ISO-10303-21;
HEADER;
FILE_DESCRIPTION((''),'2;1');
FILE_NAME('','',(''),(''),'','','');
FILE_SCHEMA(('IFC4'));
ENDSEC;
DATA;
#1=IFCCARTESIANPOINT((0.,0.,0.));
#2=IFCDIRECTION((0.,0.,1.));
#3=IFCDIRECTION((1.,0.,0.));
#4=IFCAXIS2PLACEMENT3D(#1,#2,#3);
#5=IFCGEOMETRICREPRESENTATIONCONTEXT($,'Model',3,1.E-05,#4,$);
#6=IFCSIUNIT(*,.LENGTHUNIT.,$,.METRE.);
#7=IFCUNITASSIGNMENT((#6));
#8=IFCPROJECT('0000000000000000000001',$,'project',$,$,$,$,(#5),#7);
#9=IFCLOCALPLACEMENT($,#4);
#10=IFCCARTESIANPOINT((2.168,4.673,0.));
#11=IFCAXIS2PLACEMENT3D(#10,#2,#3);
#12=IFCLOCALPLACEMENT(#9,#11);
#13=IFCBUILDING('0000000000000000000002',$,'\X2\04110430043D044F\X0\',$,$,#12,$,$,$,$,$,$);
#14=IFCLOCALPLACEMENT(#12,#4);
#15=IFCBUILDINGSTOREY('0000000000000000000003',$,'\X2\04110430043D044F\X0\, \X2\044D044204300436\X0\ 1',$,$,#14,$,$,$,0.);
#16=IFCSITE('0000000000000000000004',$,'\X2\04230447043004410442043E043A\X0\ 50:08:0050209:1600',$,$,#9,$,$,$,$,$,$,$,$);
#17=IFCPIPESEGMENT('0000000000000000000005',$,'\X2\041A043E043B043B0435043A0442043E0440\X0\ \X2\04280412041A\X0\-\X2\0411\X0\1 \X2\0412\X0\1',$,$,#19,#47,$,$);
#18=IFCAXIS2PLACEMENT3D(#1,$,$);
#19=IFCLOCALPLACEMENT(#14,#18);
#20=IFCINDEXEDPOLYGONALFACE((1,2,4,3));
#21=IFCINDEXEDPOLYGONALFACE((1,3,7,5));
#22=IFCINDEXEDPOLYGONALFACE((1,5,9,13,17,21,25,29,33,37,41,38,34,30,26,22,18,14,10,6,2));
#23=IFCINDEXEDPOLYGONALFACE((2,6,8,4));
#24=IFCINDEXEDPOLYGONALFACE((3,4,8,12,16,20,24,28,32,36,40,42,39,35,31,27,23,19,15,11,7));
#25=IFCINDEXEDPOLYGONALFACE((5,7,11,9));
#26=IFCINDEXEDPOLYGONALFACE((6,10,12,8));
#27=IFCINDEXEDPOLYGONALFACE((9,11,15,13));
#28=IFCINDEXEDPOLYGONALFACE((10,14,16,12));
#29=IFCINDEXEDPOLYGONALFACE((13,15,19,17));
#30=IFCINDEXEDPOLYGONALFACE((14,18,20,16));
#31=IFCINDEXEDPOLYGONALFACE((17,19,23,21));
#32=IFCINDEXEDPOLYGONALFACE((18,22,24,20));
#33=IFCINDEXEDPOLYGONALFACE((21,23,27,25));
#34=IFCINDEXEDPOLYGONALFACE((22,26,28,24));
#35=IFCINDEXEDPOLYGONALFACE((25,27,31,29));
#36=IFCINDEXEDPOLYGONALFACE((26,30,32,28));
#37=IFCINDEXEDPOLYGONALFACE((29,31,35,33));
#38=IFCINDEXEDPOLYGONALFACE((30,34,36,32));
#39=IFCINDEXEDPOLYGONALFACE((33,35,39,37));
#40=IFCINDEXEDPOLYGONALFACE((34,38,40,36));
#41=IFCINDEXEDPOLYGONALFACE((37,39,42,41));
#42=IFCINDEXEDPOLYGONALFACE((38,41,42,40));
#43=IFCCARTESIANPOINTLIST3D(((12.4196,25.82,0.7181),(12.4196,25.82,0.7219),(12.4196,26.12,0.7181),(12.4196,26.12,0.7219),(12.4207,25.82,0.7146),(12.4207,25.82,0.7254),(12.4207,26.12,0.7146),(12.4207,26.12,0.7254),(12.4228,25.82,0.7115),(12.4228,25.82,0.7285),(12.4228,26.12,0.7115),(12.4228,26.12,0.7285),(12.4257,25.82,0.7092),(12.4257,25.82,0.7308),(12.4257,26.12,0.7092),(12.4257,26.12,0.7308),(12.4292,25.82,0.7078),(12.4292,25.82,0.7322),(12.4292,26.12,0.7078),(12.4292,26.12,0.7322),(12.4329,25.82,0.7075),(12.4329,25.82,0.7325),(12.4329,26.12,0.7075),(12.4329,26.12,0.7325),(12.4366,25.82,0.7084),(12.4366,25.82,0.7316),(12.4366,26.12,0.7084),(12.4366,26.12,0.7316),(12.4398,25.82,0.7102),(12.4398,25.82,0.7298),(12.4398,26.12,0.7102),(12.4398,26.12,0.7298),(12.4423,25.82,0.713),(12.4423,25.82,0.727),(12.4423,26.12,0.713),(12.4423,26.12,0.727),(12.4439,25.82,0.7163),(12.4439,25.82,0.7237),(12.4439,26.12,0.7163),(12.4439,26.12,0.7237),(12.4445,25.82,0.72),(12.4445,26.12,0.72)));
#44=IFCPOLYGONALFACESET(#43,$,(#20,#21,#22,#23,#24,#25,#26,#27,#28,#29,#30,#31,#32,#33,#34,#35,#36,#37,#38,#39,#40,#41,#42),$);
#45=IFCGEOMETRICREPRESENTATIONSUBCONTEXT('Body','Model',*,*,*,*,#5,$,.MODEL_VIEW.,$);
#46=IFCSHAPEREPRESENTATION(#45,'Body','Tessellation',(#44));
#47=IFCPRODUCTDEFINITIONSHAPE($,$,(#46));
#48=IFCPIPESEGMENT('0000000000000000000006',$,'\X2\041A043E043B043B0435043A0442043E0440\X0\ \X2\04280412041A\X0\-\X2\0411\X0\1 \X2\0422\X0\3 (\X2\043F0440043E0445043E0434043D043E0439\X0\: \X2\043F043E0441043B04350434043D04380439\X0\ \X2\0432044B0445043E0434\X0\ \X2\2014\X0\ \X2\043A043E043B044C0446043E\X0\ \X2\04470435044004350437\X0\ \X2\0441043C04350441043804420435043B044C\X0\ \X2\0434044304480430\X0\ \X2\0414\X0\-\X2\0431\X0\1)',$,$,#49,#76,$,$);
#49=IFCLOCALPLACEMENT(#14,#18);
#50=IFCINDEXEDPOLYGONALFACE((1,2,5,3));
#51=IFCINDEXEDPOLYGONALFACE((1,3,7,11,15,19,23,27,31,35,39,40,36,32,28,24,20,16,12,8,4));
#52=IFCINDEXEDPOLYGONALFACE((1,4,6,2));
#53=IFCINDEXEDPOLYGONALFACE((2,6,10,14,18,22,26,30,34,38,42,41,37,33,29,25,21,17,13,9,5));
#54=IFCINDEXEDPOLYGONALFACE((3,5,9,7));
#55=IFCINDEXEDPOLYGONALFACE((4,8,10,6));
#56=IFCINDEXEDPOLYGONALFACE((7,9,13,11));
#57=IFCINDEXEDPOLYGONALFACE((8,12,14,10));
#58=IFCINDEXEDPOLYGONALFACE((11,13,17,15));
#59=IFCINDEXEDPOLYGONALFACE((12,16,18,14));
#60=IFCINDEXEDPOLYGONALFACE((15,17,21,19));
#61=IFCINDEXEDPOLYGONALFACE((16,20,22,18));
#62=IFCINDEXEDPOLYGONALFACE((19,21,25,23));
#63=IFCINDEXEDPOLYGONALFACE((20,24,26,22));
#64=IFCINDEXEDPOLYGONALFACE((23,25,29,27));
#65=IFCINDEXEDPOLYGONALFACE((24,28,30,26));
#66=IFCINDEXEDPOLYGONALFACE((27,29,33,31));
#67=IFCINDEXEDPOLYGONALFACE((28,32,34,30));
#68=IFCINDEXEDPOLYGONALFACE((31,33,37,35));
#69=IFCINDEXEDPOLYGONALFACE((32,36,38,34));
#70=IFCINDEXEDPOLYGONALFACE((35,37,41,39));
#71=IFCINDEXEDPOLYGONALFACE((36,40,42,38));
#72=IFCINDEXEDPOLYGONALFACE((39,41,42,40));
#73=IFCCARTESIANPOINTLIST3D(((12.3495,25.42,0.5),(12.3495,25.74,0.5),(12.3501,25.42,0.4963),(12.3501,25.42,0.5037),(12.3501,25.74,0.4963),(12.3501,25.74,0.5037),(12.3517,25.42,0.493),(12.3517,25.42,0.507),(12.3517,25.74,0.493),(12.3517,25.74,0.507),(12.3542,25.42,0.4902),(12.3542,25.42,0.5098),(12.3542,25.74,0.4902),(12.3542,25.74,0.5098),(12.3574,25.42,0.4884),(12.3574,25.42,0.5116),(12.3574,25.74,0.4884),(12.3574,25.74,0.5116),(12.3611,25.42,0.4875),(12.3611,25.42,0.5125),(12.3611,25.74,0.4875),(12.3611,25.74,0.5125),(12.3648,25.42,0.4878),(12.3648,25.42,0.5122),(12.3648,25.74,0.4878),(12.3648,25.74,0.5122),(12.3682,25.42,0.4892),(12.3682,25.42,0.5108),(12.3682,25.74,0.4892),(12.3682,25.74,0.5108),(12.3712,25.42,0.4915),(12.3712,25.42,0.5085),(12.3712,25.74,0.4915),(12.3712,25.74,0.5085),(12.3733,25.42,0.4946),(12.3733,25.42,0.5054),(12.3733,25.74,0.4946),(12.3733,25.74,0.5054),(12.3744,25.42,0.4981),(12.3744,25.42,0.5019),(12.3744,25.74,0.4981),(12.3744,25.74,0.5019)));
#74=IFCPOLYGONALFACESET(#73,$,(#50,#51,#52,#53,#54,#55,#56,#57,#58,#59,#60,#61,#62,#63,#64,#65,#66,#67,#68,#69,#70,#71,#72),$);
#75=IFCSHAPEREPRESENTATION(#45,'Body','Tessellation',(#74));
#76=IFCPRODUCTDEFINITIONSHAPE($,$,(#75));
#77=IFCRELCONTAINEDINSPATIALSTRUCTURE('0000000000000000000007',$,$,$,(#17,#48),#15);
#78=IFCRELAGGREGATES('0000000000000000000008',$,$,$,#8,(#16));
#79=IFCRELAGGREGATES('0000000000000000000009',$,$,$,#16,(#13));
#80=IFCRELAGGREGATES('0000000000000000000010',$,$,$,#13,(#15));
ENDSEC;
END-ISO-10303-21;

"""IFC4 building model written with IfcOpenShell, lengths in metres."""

from ifc_helpers import new_model, si_unit, frame, origin_with_axes, origin_2d, place, context, subcontext, project, spatial, circle, extrude, element, save


model = new_model("IFC4")

# Units and contexts
model_context = context("Model", 3, precision=1e-05, world=origin_with_axes())
body_context = subcontext(model_context, "Body", "Model", "MODEL_VIEW")
ifc_project = project(units=[si_unit("LENGTHUNIT", "METRE")], contexts=[model_context])

# Site, building, storey
site_placement = place(None, origin_with_axes())
site = spatial("IfcSite", under=ifc_project, at=site_placement, Name="Участок 50:08:0050209:1600")
building_placement = place(site_placement, frame((2.168, 4.673, 0.0), z_axis=(0.0, 0.0, 1.0), x_axis=(1.0, 0.0, 0.0)))
building = spatial("IfcBuilding", under=site, at=building_placement, Name="Баня")
storey_placement = place(building_placement, origin_with_axes())
storey = spatial("IfcBuildingStorey", under=building, at=storey_placement, Name="Баня, этаж 1", Elevation=0.0)

# Pipe segments
pipe_segment_1_placement = place(storey_placement, origin_with_axes())
element("IfcPipeSegment", 1, at=pipe_segment_1_placement, inside=storey, Name="Коллектор ШВК-Б1 В1", context=body_context, shape_type="SweptSolid", body=[
    extrude(circle(Radius=0.0125, at=origin_2d()), frame((12.432, 26.12, 0.72), z_axis=(0.0, -1.0, 0.0), x_axis=(1.0, 0.0, 0.0)), (0.0, 0.0, 1.0), 0.3),
])
pipe_segment_2_placement = place(storey_placement, origin_with_axes())
element("IfcPipeSegment", 2, at=pipe_segment_2_placement, inside=storey, Name="Коллектор ШВК-Б1 Т3 (проходной: последний выход — кольцо через смеситель душа Д-б1)", context=body_context, shape_type="SweptSolid", body=[
    extrude(circle(Radius=0.0125, at=origin_2d()), frame((12.362, 25.42, 0.5), z_axis=(0.0, 1.0, 0.0), x_axis=(-1.0, 0.0, 0.0)), (0.0, 0.0, 1.0), 0.32),
])

save(model, "model.ifc")
